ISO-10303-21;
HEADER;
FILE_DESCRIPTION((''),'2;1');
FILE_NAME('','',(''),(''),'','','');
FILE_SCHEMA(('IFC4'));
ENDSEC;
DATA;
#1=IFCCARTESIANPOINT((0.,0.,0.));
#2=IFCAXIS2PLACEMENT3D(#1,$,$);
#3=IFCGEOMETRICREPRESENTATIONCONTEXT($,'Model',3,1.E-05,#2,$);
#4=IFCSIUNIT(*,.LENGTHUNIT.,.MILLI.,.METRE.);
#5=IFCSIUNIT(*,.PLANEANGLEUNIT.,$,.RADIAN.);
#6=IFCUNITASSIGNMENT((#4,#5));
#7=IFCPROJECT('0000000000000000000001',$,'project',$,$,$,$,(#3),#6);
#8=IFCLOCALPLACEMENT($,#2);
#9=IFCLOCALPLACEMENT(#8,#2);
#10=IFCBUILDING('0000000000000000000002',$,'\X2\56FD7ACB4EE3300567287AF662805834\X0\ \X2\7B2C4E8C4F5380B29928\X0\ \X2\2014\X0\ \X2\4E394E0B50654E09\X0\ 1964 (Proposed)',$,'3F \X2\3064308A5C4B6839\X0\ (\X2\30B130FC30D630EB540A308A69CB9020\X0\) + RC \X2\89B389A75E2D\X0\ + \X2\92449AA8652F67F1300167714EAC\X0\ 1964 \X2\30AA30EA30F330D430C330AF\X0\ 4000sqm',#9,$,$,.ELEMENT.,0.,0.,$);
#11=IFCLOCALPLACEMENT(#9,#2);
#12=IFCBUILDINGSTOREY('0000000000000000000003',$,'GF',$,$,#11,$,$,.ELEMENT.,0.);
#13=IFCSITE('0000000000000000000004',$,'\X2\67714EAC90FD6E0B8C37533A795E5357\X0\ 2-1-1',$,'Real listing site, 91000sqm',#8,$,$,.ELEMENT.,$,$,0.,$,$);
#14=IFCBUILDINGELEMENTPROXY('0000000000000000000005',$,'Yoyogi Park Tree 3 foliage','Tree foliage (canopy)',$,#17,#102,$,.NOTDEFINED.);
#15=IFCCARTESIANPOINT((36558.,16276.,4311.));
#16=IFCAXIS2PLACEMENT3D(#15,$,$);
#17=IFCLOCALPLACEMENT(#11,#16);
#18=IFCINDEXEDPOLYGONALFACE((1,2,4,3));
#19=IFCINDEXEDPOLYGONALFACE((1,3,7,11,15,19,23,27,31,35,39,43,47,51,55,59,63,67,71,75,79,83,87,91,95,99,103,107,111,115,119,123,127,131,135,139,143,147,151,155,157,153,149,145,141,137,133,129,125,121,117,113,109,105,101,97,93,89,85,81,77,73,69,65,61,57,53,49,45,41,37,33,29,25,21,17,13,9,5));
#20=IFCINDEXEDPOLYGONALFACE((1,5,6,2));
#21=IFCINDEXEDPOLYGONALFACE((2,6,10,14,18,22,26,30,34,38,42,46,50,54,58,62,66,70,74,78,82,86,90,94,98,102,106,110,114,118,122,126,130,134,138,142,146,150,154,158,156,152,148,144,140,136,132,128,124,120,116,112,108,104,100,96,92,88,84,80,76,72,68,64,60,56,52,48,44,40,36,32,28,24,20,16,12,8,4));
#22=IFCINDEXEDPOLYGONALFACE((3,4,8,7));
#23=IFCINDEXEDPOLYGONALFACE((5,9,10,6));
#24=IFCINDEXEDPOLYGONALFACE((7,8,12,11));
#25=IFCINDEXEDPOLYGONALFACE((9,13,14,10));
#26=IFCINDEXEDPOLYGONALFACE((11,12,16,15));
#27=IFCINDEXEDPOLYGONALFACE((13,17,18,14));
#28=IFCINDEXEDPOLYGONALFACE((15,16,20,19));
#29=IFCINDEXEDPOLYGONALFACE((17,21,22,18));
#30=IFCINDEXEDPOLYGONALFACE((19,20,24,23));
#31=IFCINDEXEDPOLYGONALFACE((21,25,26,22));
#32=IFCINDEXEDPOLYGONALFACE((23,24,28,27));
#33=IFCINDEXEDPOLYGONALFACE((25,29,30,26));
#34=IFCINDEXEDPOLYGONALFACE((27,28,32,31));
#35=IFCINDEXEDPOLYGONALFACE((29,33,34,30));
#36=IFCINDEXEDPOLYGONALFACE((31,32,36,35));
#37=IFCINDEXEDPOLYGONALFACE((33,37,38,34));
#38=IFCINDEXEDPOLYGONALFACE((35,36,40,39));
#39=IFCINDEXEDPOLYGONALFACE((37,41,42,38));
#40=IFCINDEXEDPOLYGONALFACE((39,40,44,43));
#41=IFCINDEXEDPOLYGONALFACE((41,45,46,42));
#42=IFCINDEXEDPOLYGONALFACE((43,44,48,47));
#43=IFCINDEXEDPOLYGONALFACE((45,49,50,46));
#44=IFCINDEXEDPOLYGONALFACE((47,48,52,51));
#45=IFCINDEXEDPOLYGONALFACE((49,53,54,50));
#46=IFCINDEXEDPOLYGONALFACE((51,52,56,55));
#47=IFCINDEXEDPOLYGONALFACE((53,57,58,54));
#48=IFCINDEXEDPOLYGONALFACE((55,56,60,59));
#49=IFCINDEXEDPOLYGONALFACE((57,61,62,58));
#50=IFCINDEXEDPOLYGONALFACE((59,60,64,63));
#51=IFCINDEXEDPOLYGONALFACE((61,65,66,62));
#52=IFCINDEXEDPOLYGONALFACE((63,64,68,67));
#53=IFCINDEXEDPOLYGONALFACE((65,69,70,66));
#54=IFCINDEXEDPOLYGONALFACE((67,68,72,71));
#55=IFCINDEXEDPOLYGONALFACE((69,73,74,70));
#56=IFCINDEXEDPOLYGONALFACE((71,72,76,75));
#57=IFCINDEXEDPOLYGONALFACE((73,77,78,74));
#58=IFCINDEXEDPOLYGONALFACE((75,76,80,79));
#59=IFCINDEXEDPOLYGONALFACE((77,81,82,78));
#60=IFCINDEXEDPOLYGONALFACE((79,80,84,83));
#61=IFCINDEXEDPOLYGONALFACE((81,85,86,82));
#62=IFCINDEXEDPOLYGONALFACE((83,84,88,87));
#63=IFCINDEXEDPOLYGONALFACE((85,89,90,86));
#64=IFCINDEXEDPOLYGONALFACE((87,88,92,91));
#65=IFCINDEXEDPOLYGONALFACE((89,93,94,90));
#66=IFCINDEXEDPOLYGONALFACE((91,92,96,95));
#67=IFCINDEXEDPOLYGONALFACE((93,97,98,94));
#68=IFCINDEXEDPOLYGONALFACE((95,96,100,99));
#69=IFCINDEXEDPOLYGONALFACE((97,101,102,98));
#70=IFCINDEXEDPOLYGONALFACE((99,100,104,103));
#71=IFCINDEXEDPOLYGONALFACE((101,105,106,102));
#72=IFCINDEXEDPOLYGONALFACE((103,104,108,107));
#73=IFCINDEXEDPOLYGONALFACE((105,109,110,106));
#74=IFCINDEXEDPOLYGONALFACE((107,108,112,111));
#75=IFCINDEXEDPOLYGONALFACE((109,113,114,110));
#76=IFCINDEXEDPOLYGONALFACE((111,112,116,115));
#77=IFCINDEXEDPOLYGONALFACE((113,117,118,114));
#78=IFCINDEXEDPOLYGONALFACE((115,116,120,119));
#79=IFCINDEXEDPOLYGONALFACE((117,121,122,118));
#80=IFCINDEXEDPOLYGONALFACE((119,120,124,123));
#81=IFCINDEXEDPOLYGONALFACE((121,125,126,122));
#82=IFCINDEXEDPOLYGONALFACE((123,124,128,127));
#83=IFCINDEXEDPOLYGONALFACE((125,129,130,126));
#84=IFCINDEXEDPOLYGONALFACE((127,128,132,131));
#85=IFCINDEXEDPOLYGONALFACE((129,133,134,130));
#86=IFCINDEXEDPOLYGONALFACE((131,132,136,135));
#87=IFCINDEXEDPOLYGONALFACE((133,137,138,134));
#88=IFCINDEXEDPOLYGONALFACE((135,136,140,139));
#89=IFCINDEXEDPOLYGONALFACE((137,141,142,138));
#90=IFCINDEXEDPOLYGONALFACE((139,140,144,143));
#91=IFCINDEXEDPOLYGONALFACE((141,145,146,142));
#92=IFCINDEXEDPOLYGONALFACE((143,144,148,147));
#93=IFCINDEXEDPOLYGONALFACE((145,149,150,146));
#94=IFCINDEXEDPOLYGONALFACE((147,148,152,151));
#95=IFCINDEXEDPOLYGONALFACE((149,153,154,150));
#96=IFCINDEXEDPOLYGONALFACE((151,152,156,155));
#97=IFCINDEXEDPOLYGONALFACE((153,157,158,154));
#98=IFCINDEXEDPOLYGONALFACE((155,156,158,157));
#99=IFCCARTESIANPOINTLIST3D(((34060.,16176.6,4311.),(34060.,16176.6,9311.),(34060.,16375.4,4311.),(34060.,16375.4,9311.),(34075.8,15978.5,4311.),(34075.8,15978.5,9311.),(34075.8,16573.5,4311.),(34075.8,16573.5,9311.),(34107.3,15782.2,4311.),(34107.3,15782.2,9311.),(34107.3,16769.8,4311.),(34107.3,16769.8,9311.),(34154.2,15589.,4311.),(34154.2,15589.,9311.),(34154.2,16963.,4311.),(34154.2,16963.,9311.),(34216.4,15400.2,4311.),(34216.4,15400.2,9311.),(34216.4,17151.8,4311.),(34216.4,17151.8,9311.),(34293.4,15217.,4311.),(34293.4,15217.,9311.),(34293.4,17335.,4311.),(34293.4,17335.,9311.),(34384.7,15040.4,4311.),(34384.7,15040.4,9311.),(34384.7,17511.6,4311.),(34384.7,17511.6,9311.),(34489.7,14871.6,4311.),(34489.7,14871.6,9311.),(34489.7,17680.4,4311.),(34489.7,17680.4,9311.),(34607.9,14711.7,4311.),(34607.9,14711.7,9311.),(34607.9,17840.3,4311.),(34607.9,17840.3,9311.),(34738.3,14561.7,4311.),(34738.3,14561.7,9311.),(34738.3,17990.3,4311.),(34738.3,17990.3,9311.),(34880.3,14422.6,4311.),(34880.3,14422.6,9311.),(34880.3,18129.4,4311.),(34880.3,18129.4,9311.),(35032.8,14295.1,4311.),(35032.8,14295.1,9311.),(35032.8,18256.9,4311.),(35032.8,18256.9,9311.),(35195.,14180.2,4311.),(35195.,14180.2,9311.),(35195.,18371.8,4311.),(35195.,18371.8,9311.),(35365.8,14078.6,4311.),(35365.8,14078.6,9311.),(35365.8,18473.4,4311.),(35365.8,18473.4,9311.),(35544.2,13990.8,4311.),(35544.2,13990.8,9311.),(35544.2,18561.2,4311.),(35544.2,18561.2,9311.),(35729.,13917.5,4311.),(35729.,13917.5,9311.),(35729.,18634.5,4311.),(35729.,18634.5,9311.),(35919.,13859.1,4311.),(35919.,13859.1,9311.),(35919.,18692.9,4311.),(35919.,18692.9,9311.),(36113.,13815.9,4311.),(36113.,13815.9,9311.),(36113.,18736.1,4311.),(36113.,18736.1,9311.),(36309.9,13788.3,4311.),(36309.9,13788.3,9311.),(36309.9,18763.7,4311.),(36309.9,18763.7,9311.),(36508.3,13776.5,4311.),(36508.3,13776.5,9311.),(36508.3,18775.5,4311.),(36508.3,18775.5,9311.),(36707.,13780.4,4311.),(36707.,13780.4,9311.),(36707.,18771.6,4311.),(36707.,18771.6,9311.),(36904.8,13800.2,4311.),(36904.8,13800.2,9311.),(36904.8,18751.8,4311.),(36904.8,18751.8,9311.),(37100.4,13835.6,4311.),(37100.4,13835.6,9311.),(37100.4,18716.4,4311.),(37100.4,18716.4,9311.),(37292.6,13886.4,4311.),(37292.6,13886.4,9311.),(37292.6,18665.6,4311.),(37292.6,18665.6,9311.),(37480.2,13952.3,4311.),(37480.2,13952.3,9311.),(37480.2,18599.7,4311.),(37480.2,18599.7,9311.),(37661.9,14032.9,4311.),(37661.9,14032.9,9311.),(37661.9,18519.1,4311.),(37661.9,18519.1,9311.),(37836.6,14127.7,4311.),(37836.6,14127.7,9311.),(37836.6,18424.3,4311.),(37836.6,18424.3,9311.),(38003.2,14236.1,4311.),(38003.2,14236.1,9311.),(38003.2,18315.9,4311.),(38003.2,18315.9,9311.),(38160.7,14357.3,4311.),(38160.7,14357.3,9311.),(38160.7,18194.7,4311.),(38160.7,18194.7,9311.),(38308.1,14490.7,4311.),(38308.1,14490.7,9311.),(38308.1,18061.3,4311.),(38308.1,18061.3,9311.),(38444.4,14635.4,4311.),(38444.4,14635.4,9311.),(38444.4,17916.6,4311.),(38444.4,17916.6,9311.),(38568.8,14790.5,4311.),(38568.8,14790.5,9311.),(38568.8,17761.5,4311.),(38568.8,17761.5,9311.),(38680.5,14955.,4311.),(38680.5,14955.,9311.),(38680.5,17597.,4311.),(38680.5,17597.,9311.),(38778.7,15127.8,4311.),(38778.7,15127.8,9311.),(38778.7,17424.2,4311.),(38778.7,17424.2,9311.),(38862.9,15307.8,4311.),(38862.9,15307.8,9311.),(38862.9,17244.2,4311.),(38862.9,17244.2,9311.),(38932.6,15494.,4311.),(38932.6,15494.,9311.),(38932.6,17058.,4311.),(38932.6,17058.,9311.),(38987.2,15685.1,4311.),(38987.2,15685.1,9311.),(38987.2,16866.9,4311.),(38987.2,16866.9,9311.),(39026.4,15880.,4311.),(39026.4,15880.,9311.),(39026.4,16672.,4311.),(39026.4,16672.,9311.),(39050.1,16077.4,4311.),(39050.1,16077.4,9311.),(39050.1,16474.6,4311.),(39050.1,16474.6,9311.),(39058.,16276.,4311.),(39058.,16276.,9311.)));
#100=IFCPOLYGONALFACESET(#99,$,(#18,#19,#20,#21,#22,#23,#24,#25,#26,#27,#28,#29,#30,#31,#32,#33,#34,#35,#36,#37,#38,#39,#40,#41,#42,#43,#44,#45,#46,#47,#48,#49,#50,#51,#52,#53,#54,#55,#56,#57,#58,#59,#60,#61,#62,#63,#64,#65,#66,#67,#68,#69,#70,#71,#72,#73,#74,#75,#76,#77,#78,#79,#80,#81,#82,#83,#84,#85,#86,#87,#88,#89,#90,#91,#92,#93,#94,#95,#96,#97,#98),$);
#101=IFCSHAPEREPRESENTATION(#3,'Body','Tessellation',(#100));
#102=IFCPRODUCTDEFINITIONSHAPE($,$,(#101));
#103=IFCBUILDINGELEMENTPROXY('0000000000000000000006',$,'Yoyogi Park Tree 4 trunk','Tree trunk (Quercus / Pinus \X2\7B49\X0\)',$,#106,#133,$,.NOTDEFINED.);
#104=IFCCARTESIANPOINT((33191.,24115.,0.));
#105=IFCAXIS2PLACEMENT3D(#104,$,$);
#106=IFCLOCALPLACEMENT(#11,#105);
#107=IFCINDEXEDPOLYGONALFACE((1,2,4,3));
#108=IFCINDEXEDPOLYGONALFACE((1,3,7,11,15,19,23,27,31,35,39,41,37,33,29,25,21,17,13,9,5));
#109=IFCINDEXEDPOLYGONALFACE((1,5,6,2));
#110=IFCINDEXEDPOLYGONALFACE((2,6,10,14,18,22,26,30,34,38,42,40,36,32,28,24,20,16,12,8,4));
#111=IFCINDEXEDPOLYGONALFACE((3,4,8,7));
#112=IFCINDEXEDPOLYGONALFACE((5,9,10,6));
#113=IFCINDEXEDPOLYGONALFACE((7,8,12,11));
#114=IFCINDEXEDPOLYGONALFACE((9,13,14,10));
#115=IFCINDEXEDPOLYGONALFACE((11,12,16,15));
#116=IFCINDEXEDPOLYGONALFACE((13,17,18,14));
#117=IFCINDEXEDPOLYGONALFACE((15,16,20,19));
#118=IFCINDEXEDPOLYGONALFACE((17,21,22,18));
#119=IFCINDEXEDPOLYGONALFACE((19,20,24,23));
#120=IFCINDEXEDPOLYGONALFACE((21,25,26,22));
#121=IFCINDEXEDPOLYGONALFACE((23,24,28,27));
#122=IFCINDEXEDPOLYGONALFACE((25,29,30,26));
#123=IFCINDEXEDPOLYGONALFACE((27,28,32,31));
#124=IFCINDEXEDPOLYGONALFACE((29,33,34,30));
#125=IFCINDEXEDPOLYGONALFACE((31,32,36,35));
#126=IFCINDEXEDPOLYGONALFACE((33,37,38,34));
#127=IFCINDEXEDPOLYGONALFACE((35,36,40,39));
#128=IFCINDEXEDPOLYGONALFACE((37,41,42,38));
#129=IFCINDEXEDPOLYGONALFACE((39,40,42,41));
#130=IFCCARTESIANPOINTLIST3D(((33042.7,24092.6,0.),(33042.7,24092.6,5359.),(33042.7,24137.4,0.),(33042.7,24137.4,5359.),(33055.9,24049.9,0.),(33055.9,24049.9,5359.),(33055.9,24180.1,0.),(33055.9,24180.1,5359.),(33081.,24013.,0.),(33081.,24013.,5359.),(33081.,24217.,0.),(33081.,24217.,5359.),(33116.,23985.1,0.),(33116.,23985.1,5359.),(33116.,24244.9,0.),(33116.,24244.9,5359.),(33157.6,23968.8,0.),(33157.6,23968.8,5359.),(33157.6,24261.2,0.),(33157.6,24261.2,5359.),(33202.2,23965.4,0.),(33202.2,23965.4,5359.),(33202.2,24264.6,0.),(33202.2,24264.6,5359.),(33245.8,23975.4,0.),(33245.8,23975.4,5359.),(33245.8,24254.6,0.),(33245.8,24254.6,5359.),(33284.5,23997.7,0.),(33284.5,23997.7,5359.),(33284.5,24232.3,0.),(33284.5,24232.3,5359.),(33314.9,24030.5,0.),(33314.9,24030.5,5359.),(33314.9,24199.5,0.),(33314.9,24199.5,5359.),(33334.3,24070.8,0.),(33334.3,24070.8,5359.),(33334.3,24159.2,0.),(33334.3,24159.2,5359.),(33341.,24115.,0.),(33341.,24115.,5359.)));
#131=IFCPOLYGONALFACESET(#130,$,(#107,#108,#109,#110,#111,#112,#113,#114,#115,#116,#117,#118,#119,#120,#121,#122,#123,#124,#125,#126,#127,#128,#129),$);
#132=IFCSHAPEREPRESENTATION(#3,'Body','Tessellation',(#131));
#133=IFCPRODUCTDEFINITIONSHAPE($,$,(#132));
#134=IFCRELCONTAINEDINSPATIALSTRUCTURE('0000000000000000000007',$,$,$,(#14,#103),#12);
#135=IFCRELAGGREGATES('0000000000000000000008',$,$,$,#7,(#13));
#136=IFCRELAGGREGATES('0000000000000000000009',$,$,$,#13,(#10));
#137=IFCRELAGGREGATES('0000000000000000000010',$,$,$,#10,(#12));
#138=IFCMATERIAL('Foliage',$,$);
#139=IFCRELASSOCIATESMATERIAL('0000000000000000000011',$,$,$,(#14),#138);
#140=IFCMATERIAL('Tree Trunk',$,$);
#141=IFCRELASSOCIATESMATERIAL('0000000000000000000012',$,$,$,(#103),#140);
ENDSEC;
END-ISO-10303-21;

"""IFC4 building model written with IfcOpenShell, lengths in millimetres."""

from ifc_helpers import new_model, si_unit, frame, origin, origin_2d, place, context, project, spatial, circle, extrude, material, element, save


model = new_model("IFC4")

# Units and contexts
model_context = context("Model", 3, precision=1e-05, world=origin())
ifc_project = project(units=[si_unit("LENGTHUNIT", "METRE", prefix="MILLI"), si_unit("PLANEANGLEUNIT", "RADIAN")], contexts=[model_context])

# Site, building, storey
site_placement = place(None, origin())
site = spatial("IfcSite", under=ifc_project, at=site_placement, Name="東京都渋谷区神南 2-1-1", ObjectType="Real listing site, 91000sqm", CompositionType="ELEMENT", RefElevation=0.0)
building_placement = place(site_placement, origin())
building = spatial("IfcBuilding", under=site, at=building_placement, Name="国立代々木競技場 第二体育館 — 丹下健三 1964 (Proposed)", ObjectType="3F つり屋根 (ケーブル吊り構造) + RC 観覧席 + 鉄骨支柱、東京 1964 オリンピック 4000sqm", CompositionType="ELEMENT", ElevationOfRefHeight=0.0, ElevationOfTerrain=0.0)
storey_placement = place(building_placement, origin())
storey = spatial("IfcBuildingStorey", under=building, at=storey_placement, Name="GF", CompositionType="ELEMENT", Elevation=0.0)

# Building element proxies
ifc_material_1 = material(Name="Tree Trunk")
ifc_material_2 = material(Name="Foliage")
proxy_1_placement = place(storey_placement, frame((36558.0, 16276.0, 4311.0)))
element("IfcBuildingElementProxy", 1, at=proxy_1_placement, inside=storey, material=ifc_material_2, Name="Yoyogi Park Tree 3 foliage", Description="Tree foliage (canopy)", PredefinedType="NOTDEFINED", context=model_context, shape_type="SweptSolid", body=[
    extrude(circle(Radius=2500.0, at=origin_2d()), frame((36558.0, 16276.0, 4311.0)), (0.0, 0.0, 1.0), 5000.0),
])
proxy_2_placement = place(storey_placement, frame((33191.0, 24115.0, 0.0)))
element("IfcBuildingElementProxy", 2, at=proxy_2_placement, inside=storey, material=ifc_material_1, Name="Yoyogi Park Tree 4 trunk", Description="Tree trunk (Quercus / Pinus 等)", PredefinedType="NOTDEFINED", context=model_context, shape_type="SweptSolid", body=[
    extrude(circle(Radius=150.0, at=origin_2d()), frame((33191.0, 24115.0, 0.0)), (0.0, 0.0, 1.0), 5359.0),
])

save(model, "model.ifc")
